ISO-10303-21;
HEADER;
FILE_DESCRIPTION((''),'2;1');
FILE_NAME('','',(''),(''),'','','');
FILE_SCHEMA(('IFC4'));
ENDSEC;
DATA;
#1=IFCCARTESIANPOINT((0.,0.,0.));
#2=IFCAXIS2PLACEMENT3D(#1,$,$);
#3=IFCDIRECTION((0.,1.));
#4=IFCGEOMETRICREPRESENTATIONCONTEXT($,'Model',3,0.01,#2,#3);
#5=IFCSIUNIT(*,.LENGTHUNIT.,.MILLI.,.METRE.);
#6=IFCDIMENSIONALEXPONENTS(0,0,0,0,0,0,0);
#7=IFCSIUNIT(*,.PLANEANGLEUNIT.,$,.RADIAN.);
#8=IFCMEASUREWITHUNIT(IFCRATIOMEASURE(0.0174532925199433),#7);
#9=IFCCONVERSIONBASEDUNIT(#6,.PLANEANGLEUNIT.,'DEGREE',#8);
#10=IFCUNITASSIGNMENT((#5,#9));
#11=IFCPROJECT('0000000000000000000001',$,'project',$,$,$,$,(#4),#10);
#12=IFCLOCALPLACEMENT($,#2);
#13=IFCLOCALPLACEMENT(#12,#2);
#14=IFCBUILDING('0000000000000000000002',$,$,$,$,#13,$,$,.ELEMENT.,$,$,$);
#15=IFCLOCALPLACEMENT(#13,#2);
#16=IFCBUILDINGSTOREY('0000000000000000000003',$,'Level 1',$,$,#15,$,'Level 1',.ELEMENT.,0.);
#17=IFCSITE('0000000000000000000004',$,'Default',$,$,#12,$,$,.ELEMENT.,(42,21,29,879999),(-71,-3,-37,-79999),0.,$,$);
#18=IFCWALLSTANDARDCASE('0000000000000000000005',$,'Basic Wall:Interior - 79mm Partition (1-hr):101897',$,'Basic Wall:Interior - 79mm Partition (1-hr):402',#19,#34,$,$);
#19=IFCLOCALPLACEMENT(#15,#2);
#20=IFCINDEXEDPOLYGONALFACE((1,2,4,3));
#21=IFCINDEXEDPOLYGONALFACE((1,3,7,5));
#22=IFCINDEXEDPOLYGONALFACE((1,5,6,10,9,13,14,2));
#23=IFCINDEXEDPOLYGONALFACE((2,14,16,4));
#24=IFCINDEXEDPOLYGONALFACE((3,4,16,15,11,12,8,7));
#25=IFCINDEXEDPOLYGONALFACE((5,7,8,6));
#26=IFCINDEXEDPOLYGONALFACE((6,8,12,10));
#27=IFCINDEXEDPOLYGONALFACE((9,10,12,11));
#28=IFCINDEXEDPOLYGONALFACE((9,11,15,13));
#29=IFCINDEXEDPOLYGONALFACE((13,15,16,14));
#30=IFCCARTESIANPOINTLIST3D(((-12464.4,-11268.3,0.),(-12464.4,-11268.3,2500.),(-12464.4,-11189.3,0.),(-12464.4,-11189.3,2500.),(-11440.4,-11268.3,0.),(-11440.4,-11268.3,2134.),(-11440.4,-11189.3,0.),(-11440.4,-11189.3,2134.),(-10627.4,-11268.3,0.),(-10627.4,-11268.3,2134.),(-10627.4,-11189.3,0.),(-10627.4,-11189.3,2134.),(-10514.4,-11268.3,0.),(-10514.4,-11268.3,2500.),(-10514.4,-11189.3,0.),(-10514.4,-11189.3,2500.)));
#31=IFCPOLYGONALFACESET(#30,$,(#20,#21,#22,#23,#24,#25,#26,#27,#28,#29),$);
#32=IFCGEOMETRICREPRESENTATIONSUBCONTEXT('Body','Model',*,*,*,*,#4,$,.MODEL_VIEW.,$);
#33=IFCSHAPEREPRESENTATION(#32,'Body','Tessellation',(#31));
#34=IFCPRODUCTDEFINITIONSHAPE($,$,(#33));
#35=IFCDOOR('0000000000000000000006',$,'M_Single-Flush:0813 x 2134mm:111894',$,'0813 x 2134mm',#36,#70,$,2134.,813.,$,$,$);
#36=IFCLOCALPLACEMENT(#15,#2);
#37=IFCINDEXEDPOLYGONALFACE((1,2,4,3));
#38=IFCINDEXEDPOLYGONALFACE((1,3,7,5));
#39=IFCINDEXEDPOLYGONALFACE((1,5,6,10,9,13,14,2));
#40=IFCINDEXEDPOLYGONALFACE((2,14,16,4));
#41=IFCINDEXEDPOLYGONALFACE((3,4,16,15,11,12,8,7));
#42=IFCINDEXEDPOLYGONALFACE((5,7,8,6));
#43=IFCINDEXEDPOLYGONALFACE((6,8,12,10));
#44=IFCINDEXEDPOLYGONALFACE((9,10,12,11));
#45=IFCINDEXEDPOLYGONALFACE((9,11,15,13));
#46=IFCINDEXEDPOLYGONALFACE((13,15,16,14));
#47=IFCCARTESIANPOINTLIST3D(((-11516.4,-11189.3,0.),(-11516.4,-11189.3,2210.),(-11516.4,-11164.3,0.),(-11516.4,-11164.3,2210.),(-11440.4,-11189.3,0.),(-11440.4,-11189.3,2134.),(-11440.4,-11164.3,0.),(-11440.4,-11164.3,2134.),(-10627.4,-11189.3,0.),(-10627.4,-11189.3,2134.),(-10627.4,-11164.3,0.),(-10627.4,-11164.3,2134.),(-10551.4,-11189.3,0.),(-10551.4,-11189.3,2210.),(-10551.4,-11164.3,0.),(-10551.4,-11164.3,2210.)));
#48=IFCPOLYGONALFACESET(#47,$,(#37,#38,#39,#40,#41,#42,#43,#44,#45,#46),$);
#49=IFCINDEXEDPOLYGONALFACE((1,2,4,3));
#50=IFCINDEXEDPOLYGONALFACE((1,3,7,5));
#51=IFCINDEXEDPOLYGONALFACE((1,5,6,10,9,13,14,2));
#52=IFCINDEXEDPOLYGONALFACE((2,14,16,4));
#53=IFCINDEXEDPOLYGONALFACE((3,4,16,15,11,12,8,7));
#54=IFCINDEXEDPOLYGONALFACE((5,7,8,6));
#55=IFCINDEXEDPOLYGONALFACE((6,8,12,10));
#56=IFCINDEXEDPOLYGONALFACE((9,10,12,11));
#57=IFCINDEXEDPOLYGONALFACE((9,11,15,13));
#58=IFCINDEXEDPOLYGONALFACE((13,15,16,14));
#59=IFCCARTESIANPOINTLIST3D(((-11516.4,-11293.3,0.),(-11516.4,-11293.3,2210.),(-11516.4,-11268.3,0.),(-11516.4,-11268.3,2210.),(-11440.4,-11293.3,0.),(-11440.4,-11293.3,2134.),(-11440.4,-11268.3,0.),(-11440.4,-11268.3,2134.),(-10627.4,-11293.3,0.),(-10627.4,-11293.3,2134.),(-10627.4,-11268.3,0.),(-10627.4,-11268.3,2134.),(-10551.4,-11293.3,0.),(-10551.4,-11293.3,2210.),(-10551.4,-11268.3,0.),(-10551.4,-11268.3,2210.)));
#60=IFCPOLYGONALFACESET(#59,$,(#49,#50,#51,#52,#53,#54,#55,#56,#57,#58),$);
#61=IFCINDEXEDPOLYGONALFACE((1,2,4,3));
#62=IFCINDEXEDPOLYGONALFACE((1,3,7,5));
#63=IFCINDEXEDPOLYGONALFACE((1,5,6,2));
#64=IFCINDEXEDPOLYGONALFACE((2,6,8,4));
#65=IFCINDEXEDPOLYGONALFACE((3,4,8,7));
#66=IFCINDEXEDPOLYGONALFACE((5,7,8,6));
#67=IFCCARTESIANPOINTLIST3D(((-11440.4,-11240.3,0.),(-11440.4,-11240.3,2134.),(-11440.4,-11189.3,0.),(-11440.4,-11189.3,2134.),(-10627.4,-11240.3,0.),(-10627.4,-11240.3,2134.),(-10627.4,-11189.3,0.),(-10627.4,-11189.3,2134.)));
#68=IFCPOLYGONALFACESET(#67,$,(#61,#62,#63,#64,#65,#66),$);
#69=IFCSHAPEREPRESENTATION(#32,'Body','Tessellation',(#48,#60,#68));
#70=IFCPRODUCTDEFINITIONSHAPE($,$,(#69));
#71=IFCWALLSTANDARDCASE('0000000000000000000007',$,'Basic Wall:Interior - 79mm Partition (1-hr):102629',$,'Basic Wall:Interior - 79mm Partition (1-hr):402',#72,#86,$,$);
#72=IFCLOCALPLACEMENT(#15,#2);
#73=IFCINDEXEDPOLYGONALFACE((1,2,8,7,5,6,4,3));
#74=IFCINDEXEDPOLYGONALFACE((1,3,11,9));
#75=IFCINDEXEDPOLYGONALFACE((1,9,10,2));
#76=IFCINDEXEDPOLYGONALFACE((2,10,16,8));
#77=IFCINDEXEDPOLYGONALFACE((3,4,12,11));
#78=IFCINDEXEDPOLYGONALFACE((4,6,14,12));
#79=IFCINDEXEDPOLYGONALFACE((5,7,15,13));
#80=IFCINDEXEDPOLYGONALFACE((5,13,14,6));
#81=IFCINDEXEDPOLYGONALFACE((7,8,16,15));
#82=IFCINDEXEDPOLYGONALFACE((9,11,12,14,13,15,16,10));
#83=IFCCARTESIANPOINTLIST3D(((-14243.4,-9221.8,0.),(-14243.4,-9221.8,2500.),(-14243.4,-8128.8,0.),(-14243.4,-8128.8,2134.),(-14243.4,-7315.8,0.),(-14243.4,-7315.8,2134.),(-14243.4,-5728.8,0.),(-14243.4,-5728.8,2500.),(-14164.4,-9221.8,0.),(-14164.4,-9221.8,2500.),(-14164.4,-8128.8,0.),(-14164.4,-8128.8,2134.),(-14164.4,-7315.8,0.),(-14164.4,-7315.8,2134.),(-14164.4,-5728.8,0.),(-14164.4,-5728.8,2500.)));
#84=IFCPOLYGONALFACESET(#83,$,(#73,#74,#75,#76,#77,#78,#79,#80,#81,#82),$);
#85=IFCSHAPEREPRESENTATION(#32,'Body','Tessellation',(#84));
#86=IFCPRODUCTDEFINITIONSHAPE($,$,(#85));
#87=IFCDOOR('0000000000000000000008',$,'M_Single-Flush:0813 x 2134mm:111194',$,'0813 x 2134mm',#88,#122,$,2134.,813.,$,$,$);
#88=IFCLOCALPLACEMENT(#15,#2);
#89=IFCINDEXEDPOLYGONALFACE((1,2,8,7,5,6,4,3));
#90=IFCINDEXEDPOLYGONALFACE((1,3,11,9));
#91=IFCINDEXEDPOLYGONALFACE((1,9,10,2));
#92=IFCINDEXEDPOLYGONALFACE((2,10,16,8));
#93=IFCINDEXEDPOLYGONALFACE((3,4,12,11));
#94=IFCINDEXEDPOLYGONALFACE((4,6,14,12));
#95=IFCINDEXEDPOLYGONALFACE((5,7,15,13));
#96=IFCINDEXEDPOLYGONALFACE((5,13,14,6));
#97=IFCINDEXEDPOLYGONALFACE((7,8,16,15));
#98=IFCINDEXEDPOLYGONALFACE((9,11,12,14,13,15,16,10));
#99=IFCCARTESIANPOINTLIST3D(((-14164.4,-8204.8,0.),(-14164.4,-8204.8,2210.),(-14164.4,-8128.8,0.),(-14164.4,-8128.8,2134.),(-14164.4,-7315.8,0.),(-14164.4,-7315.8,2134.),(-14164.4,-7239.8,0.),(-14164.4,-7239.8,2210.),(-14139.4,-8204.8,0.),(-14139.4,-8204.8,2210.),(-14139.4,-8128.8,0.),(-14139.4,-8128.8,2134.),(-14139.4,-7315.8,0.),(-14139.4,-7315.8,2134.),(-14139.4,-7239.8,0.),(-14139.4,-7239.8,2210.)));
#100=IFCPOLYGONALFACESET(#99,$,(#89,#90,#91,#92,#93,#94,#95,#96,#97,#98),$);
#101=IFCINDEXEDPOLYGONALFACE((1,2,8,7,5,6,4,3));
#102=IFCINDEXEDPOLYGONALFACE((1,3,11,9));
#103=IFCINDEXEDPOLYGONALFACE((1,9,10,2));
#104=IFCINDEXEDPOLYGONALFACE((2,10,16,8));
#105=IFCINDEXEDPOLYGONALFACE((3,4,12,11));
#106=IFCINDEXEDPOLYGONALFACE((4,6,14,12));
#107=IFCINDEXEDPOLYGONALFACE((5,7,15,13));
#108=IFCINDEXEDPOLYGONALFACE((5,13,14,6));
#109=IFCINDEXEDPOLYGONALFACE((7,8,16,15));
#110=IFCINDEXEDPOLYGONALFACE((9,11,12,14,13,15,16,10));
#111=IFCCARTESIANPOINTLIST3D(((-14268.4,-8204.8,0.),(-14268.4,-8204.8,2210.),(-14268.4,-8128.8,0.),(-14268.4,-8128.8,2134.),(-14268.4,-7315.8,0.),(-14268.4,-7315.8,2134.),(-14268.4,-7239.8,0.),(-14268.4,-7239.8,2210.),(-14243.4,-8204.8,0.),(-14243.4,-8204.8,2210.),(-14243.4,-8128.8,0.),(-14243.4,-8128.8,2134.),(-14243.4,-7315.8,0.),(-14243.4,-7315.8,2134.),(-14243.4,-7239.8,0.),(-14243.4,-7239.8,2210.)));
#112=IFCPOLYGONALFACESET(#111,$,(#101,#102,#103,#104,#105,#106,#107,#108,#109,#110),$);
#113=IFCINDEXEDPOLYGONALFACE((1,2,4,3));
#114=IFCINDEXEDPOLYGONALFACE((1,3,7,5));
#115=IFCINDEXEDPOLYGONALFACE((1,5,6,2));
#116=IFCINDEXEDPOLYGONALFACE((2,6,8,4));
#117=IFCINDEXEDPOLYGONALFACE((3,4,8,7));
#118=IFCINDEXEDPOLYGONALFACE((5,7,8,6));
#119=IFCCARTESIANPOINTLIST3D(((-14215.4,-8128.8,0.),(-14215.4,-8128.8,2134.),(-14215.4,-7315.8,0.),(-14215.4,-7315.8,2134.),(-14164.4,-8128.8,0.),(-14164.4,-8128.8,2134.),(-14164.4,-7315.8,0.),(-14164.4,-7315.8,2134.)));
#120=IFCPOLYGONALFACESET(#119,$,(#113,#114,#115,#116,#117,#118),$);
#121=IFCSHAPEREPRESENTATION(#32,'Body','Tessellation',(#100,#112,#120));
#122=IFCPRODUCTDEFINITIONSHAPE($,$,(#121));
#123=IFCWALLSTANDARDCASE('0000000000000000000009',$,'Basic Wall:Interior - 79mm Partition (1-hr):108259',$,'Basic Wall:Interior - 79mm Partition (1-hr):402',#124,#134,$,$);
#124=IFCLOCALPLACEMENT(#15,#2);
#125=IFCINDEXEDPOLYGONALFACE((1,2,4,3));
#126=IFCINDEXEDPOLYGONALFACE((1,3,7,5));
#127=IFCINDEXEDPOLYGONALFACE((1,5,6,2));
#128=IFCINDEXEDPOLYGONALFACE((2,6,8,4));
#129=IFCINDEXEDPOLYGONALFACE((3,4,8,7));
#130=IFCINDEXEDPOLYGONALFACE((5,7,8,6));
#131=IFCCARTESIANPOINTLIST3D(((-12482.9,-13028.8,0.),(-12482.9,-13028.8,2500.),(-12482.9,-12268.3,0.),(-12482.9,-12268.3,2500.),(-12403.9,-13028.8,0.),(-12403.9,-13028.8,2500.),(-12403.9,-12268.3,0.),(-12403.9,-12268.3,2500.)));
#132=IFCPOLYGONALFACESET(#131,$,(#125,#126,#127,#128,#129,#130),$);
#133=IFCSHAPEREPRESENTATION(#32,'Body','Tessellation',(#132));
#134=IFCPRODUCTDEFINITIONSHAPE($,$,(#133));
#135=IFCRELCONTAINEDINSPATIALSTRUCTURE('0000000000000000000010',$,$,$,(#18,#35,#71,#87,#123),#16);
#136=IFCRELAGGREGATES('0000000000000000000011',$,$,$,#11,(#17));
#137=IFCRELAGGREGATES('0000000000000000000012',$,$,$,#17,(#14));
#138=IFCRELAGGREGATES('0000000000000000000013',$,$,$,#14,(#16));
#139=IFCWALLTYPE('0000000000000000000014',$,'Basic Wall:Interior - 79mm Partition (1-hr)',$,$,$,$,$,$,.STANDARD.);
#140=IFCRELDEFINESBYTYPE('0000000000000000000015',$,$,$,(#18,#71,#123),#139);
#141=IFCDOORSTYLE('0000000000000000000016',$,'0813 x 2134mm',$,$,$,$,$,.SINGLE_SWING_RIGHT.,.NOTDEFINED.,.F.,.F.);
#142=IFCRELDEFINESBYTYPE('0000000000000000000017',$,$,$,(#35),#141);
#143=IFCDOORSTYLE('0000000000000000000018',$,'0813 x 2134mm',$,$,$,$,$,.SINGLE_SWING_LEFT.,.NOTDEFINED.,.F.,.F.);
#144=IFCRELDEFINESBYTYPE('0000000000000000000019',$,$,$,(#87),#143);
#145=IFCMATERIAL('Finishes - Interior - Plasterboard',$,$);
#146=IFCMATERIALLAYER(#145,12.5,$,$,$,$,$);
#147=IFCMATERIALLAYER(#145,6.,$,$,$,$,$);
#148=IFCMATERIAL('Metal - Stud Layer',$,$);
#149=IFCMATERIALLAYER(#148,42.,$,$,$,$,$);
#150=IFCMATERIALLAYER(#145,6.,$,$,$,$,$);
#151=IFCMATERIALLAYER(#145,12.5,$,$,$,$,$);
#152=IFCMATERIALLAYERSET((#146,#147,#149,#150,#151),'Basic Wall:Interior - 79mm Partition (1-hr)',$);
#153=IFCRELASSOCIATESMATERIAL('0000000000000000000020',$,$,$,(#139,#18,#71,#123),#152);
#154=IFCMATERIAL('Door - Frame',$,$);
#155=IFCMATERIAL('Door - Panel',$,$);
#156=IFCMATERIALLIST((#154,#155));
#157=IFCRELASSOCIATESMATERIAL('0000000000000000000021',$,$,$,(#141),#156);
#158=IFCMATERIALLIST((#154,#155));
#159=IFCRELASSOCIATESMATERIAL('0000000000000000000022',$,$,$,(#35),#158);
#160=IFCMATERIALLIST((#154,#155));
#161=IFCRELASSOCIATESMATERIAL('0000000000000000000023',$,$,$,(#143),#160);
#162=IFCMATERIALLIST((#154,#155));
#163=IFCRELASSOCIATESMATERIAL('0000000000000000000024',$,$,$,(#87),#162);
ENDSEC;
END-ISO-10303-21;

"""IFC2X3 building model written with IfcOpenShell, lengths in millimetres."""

from ifc_helpers import new_model, entity, si_unit, converted_unit, direction, frame, frame_2d, origin, origin_2d_with_axis, place, context, subcontext, project, spatial, polyline, rectangle, outline, extrude, source, transform, mapped, material, material_list, layer, layer_set, layer_usage, type_object, type_shapes, element, fill, save


model = new_model("IFC2X3")

# Units and contexts
model_context = context("Model", 3, precision=0.01, world=origin(), true_north=direction((0.0, 1.0)))
body_context = subcontext(model_context, "Body", "Model", "MODEL_VIEW")
ifc_project = project(units=[si_unit("LENGTHUNIT", "METRE", prefix="MILLI"), converted_unit("PLANEANGLEUNIT", "DEGREE", entity("IfcRatioMeasure", 0.0174532925199433), si_unit("PLANEANGLEUNIT", "RADIAN"), dimensions=[0, 0, 0, 0, 0, 0, 0])], contexts=[model_context])

# Site, building, storey
site_placement = place(None, origin())
site = spatial("IfcSite", under=ifc_project, at=site_placement, Name="Default", CompositionType="ELEMENT", RefLatitude=(42, 21, 29, 879999), RefLongitude=(-71, -3, -37, -79999), RefElevation=0.0)
building_placement = place(site_placement, origin())
building = spatial("IfcBuilding", under=site, at=building_placement, CompositionType="ELEMENT")
storey_placement = place(building_placement, origin())
storey = spatial("IfcBuildingStorey", under=building, at=storey_placement, Name="Level 1", LongName="Level 1", CompositionType="ELEMENT", Elevation=0.0)

# Shared definitions
ifc_material_1 = material(Name="Door - Frame")
ifc_material_2 = material(Name="Door - Panel")

# Shared definitions
ifc_material_3 = material(Name="Finishes - Interior - Plasterboard")
ifc_layer_1 = layer(ifc_material_3, 12.5)
ifc_layer_2 = layer(ifc_material_3, 6.0)
ifc_material_4 = material(Name="Metal - Stud Layer")
ifc_layer_3 = layer(ifc_material_4, 42.0)
ifc_layer_4 = layer(ifc_material_3, 6.0)
ifc_layer_5 = layer(ifc_material_3, 12.5)
ifc_layer_set_1 = layer_set([ifc_layer_1, ifc_layer_2, ifc_layer_3, ifc_layer_4, ifc_layer_5], Name="Basic Wall:Interior - 79mm Partition (1-hr)")
wall_type_1 = type_object("IfcWallType", Name="Basic Wall:Interior - 79mm Partition (1-hr)", PredefinedType="STANDARD", material=ifc_layer_set_1)

# Walls, openings, doors
ifc_material_list_1 = material_list([ifc_material_1, ifc_material_2])
door_style_1 = type_object("IfcDoorStyle", Name="0813 x 2134mm", ConstructionType="NOTDEFINED", OperationType="SINGLE_SWING_RIGHT", ParameterTakesPrecedence=False, Sizeable=False, material=ifc_material_list_1)
shared_shape_1 = source(origin(), body_context, "Body", "SweptSolid", [
    extrude(outline(polyline([(-482.5, -1124.0), (482.5, -1124.0), (482.5, 1086.0), (406.5, 1086.0), (406.5, -1048.0), (-406.5, -1048.0), (-406.5, 1086.0), (-482.5, 1086.0), (-482.5, -1124.0)])), frame((406.5, 79.0, 1086.0), z_axis=(0.0, 1.0, 0.0), x_axis=(1.0, 0.0, 0.0)), (0.0, 0.0, 1.0), 25.0),
    extrude(outline(polyline([(-1124.0, -482.5), (1086.0, -482.5), (1086.0, -406.5), (-1048.0, -406.5), (-1048.0, 406.5), (1086.0, 406.5), (1086.0, 482.5), (-1124.0, 482.5), (-1124.0, -482.5)])), frame((406.5, -25.0, 1086.0), z_axis=(0.0, 1.0, 0.0), x_axis=(0.0, 0.0, -1.0)), (0.0, 0.0, 1.0), 25.0),
    extrude(rectangle(XDim=51.0, YDim=813.0, at=origin_2d_with_axis()), frame((406.5, 53.5, 0.0), z_axis=(0.0, 0.0, 1.0), x_axis=(0.0, 1.0, 0.0)), (0.0, 0.0, 1.0), 2134.0),
])
type_shapes(door_style_1, [shared_shape_1])
ifc_layer_usage_1 = layer_usage(ifc_layer_set_1, "AXIS2", "NEGATIVE", 39.5)
wall_1_placement = place(storey_placement, frame((-12464.4, -11228.8, 0.0)))
wall_1 = element("IfcWallStandardCase", 1, at=wall_1_placement, inside=storey, type_object=wall_type_1, material=ifc_layer_usage_1, Name="Basic Wall:Interior - 79mm Partition (1-hr):101897", ObjectType="Basic Wall:Interior - 79mm Partition (1-hr):402", context=body_context, shape_type="SweptSolid", body=[
    extrude(rectangle(XDim=1950.0, YDim=79.0, at=frame_2d((975.0, 0.0), x_axis=(-1.0, 0.0))), origin(), (0.0, 0.0, 1.0), 2500.0),
])
opening_1_placement = place(wall_1_placement, frame((1024.0, -39.5, 0.0)))
opening_1 = element("IfcOpeningElement", 2, at=opening_1_placement, cuts=wall_1, ObjectType="Opening", context=body_context, shape_type="SweptSolid", body=[
    extrude(rectangle(XDim=813.0, YDim=2134.0, at=frame_2d((1067.0, 406.5), x_axis=(0.0, 1.0))), frame((0.0, 0.0, 0.0), z_axis=(0.0, 1.0, 0.0), x_axis=(0.0, 0.0, 1.0)), (0.0, 0.0, 1.0), 79.0),
])
ifc_material_list_2 = material_list([ifc_material_1, ifc_material_2])
door_1_placement = place(opening_1_placement, origin())
door_1 = element("IfcDoor", 3, at=door_1_placement, inside=storey, type_object=door_style_1, material=ifc_material_list_2, Name="M_Single-Flush:0813 x 2134mm:111894", ObjectType="0813 x 2134mm", OverallHeight=2134.0, OverallWidth=813.0, context=body_context, shape_type="MappedRepresentation", body=[
    mapped(shared_shape_1, transform((0.0, 0.0, 0.0), scale=1.0)),
])
fill(opening_1, door_1)
ifc_layer_usage_2 = layer_usage(ifc_layer_set_1, "AXIS2", "NEGATIVE", 39.5)
wall_2_placement = place(storey_placement, frame((-14203.9, -9221.8, 0.0), z_axis=(0.0, 0.0, 1.0), x_axis=(0.0, 1.0, 0.0)))
wall_2 = element("IfcWallStandardCase", 4, at=wall_2_placement, inside=storey, type_object=wall_type_1, material=ifc_layer_usage_2, Name="Basic Wall:Interior - 79mm Partition (1-hr):102629", ObjectType="Basic Wall:Interior - 79mm Partition (1-hr):402", context=body_context, shape_type="SweptSolid", body=[
    extrude(rectangle(XDim=3493.0, YDim=79.0, at=frame_2d((1746.5, 0.0), x_axis=(-1.0, 0.0))), origin(), (0.0, 0.0, 1.0), 2500.0),
])
opening_2_placement = place(wall_2_placement, frame((1906.0, 39.5, 0.0)))
opening_2 = element("IfcOpeningElement", 5, at=opening_2_placement, cuts=wall_2, ObjectType="Opening", context=body_context, shape_type="SweptSolid", body=[
    extrude(rectangle(XDim=813.0, YDim=2134.0, at=frame_2d((1067.0, 406.5), x_axis=(0.0, -1.0))), frame((0.0, 0.0, 0.0), z_axis=(0.0, -1.0, 0.0), x_axis=(0.0, 0.0, 1.0)), (0.0, 0.0, 1.0), 79.0),
])
ifc_material_list_3 = material_list([ifc_material_1, ifc_material_2])
ifc_material_list_4 = material_list([ifc_material_1, ifc_material_2])
door_style_2 = type_object("IfcDoorStyle", Name="0813 x 2134mm", ConstructionType="NOTDEFINED", OperationType="SINGLE_SWING_LEFT", ParameterTakesPrecedence=False, Sizeable=False, material=ifc_material_list_4)
shared_shape_2 = source(origin(), body_context, "Body", "SweptSolid", [
    extrude(outline(polyline([(-482.5, -1124.0), (482.5, -1124.0), (482.5, 1086.0), (406.5, 1086.0), (406.5, -1048.0), (-406.5, -1048.0), (-406.5, 1086.0), (-482.5, 1086.0), (-482.5, -1124.0)])), frame((406.5, 104.0, 1086.0), z_axis=(0.0, -1.0, 0.0), x_axis=(-1.0, 0.0, 0.0)), (0.0, 0.0, 1.0), 25.0),
    extrude(outline(polyline([(-1124.0, -482.5), (1086.0, -482.5), (1086.0, -406.5), (-1048.0, -406.5), (-1048.0, 406.5), (1086.0, 406.5), (1086.0, 482.5), (-1124.0, 482.5), (-1124.0, -482.5)])), frame((406.5, 0.0, 1086.0), z_axis=(0.0, -1.0, 0.0), x_axis=(0.0, 0.0, -1.0)), (0.0, 0.0, 1.0), 25.0),
    extrude(rectangle(XDim=813.0, YDim=51.0, at=origin_2d_with_axis()), frame((406.5, 53.5, 0.0)), (0.0, 0.0, 1.0), 2134.0),
])
type_shapes(door_style_2, [shared_shape_2])
door_2_placement = place(opening_2_placement, frame((0.0, 0.0, 0.0), z_axis=(0.0, 0.0, 1.0), x_axis=(-1.0, 0.0, 0.0)))
door_2 = element("IfcDoor", 6, at=door_2_placement, inside=storey, type_object=door_style_2, material=ifc_material_list_3, Name="M_Single-Flush:0813 x 2134mm:111194", ObjectType="0813 x 2134mm", OverallHeight=2134.0, OverallWidth=813.0, context=body_context, shape_type="MappedRepresentation", body=[
    mapped(shared_shape_2, transform((0.0, 0.0, 0.0), scale=1.0)),
])
fill(opening_2, door_2)

# Wall
ifc_layer_usage_3 = layer_usage(ifc_layer_set_1, "AXIS2", "NEGATIVE", 39.5)
wall_3_placement = place(storey_placement, frame((-12443.4, -12268.3, 0.0), z_axis=(0.0, 0.0, 1.0), x_axis=(0.0, -1.0, 0.0)))
element("IfcWallStandardCase", 7, at=wall_3_placement, inside=storey, type_object=wall_type_1, material=ifc_layer_usage_3, Name="Basic Wall:Interior - 79mm Partition (1-hr):108259", ObjectType="Basic Wall:Interior - 79mm Partition (1-hr):402", context=body_context, shape_type="SweptSolid", body=[
    extrude(rectangle(XDim=760.5, YDim=79.0, at=frame_2d((380.2, 0.0), x_axis=(-1.0, 0.0))), origin(), (0.0, 0.0, 1.0), 2500.0),
])

save(model, "model.ifc")
